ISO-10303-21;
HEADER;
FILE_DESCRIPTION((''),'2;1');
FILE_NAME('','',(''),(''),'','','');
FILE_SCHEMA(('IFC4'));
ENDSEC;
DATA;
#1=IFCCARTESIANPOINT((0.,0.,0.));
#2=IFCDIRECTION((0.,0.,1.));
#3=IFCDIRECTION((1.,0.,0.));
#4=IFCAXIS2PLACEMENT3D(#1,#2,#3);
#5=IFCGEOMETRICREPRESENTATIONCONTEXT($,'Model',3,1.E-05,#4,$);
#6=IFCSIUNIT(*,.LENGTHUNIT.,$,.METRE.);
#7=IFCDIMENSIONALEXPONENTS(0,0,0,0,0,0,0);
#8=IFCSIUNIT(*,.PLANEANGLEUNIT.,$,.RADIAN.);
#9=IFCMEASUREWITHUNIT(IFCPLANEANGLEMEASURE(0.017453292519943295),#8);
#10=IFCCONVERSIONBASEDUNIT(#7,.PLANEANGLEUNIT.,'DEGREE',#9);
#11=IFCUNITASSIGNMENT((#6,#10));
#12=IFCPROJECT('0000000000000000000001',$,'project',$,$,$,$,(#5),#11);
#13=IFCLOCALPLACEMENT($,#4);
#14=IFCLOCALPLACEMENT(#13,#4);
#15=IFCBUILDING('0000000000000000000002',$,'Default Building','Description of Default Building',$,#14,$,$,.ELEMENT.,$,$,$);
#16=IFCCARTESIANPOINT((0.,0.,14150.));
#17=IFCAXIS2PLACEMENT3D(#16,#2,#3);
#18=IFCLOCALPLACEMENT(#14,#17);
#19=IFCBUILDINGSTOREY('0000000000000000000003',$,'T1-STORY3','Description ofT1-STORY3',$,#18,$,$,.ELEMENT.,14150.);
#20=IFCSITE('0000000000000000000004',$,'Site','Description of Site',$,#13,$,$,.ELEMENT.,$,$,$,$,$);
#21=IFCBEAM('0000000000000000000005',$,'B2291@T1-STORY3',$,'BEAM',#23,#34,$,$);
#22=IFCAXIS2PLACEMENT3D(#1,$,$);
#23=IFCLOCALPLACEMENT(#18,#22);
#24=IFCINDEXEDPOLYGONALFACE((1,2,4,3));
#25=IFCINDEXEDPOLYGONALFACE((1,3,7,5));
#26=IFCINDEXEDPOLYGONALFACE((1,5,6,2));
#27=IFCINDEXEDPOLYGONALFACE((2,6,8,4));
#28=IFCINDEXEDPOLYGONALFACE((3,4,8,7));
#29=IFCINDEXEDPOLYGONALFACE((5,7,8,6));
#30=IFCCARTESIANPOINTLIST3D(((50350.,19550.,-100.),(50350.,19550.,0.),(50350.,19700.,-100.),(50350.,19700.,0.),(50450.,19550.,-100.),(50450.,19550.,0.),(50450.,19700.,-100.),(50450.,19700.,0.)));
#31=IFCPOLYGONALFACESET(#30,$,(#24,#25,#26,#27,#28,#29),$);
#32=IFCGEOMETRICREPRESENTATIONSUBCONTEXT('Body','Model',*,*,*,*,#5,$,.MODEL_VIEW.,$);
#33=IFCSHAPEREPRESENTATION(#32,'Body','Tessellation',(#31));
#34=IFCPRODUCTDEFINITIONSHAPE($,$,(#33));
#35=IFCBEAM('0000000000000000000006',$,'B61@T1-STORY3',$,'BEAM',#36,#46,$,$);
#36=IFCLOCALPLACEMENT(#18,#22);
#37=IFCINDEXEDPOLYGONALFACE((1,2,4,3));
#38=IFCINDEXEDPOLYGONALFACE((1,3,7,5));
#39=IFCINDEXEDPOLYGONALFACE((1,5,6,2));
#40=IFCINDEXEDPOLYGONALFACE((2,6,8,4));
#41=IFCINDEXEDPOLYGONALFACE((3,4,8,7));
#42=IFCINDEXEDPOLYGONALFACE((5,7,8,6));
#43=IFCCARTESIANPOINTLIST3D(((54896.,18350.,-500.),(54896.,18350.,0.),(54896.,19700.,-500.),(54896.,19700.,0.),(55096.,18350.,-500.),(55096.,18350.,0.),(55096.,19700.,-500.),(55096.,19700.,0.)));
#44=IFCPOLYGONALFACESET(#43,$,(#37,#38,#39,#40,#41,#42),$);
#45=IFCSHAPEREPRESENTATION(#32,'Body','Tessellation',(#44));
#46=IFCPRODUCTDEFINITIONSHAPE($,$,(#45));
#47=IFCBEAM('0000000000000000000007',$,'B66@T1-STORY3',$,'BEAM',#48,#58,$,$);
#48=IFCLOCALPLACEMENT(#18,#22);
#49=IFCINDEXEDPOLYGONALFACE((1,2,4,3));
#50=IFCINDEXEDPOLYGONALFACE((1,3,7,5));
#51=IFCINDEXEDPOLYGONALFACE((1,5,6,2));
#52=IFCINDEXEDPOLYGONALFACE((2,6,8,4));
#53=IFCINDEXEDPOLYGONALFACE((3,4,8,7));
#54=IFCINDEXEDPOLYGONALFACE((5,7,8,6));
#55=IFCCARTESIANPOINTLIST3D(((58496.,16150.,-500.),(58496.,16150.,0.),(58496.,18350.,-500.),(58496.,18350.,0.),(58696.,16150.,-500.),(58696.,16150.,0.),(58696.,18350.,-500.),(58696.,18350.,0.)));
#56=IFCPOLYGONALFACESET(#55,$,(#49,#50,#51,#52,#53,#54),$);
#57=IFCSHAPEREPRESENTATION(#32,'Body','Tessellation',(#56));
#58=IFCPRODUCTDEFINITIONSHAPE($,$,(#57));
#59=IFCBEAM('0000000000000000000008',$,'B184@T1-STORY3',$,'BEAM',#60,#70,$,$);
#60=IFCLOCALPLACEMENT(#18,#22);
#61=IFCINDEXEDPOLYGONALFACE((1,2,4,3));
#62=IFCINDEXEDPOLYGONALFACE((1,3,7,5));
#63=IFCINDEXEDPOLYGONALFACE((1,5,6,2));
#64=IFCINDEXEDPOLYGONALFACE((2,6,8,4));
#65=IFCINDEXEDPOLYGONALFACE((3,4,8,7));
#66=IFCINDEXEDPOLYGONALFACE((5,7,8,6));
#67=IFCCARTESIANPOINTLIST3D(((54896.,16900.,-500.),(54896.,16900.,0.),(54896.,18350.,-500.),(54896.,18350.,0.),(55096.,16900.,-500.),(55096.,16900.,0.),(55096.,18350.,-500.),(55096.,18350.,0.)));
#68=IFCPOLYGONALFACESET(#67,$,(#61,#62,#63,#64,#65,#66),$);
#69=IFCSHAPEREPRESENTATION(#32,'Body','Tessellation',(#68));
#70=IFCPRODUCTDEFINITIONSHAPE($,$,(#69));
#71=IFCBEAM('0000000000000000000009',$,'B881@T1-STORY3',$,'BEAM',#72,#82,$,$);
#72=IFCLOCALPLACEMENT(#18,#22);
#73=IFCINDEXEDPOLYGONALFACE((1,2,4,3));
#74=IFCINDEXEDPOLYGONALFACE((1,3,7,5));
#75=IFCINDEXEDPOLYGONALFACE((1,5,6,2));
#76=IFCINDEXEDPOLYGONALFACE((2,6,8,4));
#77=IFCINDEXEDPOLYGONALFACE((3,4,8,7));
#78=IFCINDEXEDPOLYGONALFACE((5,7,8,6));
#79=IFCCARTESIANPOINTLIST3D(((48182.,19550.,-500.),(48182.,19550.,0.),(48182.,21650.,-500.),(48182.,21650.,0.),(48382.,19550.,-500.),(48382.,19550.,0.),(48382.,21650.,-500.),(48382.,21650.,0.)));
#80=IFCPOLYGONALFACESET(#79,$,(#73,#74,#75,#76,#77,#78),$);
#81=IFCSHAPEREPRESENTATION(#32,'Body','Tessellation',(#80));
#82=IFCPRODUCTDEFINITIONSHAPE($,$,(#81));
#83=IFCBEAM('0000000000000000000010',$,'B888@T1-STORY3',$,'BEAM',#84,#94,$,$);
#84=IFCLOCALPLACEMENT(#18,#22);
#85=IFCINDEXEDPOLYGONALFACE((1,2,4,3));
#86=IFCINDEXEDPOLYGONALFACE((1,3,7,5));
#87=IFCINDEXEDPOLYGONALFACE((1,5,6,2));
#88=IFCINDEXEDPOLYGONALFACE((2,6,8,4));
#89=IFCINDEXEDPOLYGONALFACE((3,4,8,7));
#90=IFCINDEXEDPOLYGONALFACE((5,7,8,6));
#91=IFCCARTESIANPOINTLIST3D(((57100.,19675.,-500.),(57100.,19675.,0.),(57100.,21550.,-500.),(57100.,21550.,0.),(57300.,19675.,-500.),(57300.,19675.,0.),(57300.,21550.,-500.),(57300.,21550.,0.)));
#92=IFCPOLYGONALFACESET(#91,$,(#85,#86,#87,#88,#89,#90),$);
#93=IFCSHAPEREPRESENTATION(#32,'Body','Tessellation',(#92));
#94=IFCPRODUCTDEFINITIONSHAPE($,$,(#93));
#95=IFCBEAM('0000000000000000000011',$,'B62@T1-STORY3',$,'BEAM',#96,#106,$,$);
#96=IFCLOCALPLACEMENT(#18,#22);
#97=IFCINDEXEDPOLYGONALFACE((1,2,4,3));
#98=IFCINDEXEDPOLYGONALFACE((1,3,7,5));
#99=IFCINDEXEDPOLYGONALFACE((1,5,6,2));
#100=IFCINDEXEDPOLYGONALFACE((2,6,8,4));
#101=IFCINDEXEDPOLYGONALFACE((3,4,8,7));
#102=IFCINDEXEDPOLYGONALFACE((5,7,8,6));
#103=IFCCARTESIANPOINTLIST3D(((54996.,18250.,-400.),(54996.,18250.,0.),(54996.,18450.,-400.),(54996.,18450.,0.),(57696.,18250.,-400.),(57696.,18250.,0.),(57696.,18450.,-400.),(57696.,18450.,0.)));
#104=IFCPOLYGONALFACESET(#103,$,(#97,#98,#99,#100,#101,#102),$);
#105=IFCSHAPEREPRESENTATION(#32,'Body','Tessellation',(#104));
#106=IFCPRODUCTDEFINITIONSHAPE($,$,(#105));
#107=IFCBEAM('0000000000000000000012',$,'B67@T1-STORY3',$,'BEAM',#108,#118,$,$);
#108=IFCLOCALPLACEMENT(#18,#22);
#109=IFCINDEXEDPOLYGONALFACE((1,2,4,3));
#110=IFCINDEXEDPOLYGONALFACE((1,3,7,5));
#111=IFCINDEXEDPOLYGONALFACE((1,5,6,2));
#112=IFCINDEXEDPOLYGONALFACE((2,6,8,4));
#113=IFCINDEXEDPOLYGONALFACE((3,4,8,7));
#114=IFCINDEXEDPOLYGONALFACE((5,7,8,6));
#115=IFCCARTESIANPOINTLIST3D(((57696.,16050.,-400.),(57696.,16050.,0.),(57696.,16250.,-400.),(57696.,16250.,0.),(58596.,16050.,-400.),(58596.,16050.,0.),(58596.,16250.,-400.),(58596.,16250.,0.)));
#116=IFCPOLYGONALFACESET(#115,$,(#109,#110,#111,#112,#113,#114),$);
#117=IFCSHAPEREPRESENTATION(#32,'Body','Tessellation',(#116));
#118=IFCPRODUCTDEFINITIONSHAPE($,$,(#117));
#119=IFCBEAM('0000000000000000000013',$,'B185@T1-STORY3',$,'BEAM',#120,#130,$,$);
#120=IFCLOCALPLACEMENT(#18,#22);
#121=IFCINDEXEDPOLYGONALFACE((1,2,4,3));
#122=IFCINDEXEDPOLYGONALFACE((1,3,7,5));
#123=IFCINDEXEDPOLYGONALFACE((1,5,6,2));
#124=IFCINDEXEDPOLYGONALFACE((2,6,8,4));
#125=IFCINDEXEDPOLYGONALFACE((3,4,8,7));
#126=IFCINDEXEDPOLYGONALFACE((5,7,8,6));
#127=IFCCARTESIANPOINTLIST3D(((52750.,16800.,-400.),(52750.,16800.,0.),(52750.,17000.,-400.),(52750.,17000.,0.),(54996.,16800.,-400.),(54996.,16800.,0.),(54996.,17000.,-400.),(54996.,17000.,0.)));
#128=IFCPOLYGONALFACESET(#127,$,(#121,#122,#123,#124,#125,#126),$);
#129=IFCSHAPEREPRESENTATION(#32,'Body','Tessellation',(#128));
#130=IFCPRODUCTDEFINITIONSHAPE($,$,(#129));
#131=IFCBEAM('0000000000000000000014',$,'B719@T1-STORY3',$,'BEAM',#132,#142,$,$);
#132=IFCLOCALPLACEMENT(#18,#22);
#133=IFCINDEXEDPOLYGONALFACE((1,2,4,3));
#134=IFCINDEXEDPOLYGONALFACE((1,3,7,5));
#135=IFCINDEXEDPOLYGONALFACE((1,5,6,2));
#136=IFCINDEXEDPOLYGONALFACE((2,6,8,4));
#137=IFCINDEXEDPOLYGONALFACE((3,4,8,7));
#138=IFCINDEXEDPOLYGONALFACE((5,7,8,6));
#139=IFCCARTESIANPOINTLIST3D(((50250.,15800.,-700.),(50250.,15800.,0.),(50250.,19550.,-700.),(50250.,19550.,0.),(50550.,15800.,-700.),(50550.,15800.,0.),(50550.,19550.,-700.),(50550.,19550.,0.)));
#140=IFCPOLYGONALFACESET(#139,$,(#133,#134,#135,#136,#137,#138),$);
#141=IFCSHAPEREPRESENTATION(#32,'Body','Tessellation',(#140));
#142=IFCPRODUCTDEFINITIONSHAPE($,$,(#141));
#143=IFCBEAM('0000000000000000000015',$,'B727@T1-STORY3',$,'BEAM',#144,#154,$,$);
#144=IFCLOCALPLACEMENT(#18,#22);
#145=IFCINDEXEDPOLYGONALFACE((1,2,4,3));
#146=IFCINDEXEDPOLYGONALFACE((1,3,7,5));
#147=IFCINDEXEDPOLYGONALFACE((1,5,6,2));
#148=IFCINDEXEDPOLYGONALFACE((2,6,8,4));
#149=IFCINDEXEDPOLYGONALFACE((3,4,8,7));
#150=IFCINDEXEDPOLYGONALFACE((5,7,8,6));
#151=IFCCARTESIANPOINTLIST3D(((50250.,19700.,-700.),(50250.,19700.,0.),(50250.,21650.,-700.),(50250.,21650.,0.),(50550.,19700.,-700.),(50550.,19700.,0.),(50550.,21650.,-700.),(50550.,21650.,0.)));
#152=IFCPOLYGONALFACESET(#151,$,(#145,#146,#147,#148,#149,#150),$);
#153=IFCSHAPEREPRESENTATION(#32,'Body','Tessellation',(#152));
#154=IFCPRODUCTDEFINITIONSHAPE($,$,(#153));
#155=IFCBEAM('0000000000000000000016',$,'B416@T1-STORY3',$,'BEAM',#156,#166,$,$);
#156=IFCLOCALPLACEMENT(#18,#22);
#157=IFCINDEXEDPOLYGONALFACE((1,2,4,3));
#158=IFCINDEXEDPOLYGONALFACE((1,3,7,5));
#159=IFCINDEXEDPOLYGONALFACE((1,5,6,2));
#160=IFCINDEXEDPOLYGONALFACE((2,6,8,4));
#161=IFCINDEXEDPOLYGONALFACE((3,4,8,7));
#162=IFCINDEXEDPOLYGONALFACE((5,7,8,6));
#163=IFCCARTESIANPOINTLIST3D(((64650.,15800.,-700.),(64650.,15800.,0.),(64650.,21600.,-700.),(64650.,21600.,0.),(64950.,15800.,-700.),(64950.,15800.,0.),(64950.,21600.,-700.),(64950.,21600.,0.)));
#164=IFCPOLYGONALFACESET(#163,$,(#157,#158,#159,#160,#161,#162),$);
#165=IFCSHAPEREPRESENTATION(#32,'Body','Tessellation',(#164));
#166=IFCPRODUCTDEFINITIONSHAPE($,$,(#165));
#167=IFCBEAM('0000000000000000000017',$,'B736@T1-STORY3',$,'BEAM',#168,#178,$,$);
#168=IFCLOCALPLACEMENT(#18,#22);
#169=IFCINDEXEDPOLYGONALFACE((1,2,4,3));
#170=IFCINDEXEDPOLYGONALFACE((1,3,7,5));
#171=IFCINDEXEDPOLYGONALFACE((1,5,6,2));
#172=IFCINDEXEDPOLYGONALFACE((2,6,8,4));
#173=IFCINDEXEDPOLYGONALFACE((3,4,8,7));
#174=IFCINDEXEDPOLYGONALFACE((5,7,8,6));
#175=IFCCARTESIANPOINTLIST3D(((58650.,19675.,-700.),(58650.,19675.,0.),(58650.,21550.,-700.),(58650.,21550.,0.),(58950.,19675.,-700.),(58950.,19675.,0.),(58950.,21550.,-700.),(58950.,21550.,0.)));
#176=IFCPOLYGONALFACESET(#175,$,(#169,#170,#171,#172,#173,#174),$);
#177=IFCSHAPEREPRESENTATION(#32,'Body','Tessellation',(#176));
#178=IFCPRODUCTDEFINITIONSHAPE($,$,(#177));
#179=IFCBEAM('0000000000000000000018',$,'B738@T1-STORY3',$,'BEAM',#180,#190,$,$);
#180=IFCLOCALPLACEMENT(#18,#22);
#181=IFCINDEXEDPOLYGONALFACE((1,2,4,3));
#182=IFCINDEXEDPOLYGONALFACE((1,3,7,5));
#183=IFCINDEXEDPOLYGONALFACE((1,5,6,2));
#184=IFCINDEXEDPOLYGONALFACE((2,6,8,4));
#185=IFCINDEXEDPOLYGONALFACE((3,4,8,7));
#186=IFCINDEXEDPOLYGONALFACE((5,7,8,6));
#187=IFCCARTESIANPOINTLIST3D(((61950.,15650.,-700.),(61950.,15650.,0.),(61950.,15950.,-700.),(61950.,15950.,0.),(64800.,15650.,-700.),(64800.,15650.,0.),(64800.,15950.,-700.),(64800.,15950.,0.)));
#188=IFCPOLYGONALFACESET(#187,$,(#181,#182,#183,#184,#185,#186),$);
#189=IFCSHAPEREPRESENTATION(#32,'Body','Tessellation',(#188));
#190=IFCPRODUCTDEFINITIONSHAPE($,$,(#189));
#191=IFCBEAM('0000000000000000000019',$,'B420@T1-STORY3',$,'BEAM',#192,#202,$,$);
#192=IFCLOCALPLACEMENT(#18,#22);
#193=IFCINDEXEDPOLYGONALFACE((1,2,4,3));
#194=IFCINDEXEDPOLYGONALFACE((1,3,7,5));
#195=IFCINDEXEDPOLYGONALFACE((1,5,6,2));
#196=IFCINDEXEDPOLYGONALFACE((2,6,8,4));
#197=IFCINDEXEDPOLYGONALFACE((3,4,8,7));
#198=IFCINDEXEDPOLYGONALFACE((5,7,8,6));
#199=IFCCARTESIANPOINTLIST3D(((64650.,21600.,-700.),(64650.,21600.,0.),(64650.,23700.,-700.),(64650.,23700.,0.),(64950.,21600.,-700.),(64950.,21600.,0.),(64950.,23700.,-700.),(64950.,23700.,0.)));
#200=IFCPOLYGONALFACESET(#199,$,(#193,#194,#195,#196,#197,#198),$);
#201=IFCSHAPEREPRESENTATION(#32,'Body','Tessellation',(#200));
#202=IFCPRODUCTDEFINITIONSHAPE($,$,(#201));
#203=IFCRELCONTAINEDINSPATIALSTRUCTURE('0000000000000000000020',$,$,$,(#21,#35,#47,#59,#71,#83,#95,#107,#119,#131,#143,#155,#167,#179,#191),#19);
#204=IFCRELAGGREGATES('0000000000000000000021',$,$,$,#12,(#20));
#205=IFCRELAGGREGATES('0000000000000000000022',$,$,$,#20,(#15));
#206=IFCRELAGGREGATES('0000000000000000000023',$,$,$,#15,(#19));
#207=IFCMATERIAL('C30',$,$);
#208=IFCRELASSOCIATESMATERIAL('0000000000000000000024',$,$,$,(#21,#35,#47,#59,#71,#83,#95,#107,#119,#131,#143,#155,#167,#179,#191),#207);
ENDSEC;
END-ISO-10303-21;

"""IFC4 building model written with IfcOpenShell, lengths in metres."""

from ifc_helpers import new_model, entity, si_unit, converted_unit, frame, origin_with_axes, place, context, subcontext, project, spatial, rectangle, extrude, material, element, save


model = new_model("IFC4")

# Units and contexts
model_context = context("Model", 3, precision=1e-05, world=origin_with_axes())
body_context = subcontext(model_context, "Body", "Model", "MODEL_VIEW")
ifc_project = project(units=[si_unit("LENGTHUNIT", "METRE"), converted_unit("PLANEANGLEUNIT", "DEGREE", entity("IfcPlaneAngleMeasure", 0.017453292519943295), si_unit("PLANEANGLEUNIT", "RADIAN"), dimensions=[0, 0, 0, 0, 0, 0, 0])], contexts=[model_context])

# Site, building, storey
site_placement = place(None, origin_with_axes())
site = spatial("IfcSite", under=ifc_project, at=site_placement, Name="Site", Description="Description of Site", CompositionType="ELEMENT")
building_placement = place(site_placement, origin_with_axes())
building = spatial("IfcBuilding", under=site, at=building_placement, Name="Default Building", Description="Description of Default Building", CompositionType="ELEMENT")
storey_placement = place(building_placement, frame((0.0, 0.0, 14150.0), z_axis=(0.0, 0.0, 1.0), x_axis=(1.0, 0.0, 0.0)))
storey = spatial("IfcBuildingStorey", under=building, at=storey_placement, Name="T1-STORY3", Description="Description ofT1-STORY3", CompositionType="ELEMENT", Elevation=14150.0)

# Beams
ifc_material_1 = material(Name="C30")
beam_1_placement = place(storey_placement, frame((50400.0, 19550.0, -50.0), z_axis=(0.0, 1.0, 0.0), x_axis=(-1.0, 0.0, 0.0)))
element("IfcBeam", 1, at=beam_1_placement, inside=storey, material=ifc_material_1, Name="B2291@T1-STORY3", ObjectType="BEAM", context=body_context, shape_type="SweptSolid", body=[
    extrude(rectangle(XDim=100.0, YDim=100.0), origin_with_axes(), (0.0, 0.0, 1.0), 150.0),
])
beam_2_placement = place(storey_placement, frame((54996.0, 18350.0, -250.0), z_axis=(0.0, 1.0, 0.0), x_axis=(-1.0, 0.0, 0.0)))
element("IfcBeam", 2, at=beam_2_placement, inside=storey, material=ifc_material_1, Name="B61@T1-STORY3", ObjectType="BEAM", context=body_context, shape_type="SweptSolid", body=[
    extrude(rectangle(XDim=200.0, YDim=500.0), origin_with_axes(), (0.0, 0.0, 1.0), 1350.0),
])
beam_3_placement = place(storey_placement, frame((58596.0, 16150.0, -250.0), z_axis=(0.0, 1.0, 0.0), x_axis=(-1.0, 0.0, 0.0)))
element("IfcBeam", 3, at=beam_3_placement, inside=storey, material=ifc_material_1, Name="B66@T1-STORY3", ObjectType="BEAM", context=body_context, shape_type="SweptSolid", body=[
    extrude(rectangle(XDim=200.0, YDim=500.0), origin_with_axes(), (0.0, 0.0, 1.0), 2200.0),
])
beam_4_placement = place(storey_placement, frame((54996.0, 16900.0, -250.0), z_axis=(0.0, 1.0, 0.0), x_axis=(-1.0, 0.0, 0.0)))
element("IfcBeam", 4, at=beam_4_placement, inside=storey, material=ifc_material_1, Name="B184@T1-STORY3", ObjectType="BEAM", context=body_context, shape_type="SweptSolid", body=[
    extrude(rectangle(XDim=200.0, YDim=500.0), origin_with_axes(), (0.0, 0.0, 1.0), 1450.0),
])
beam_5_placement = place(storey_placement, frame((48282.0, 19550.0, -250.0), z_axis=(0.0, 1.0, 0.0), x_axis=(-1.0, 0.0, 0.0)))
element("IfcBeam", 5, at=beam_5_placement, inside=storey, material=ifc_material_1, Name="B881@T1-STORY3", ObjectType="BEAM", context=body_context, shape_type="SweptSolid", body=[
    extrude(rectangle(XDim=200.0, YDim=500.0), origin_with_axes(), (0.0, 0.0, 1.0), 2100.0),
])
beam_6_placement = place(storey_placement, frame((57200.0, 19675.0, -250.0), z_axis=(0.0, 1.0, 0.0), x_axis=(-1.0, 0.0, 0.0)))
element("IfcBeam", 6, at=beam_6_placement, inside=storey, material=ifc_material_1, Name="B888@T1-STORY3", ObjectType="BEAM", context=body_context, shape_type="SweptSolid", body=[
    extrude(rectangle(XDim=200.0, YDim=500.0), origin_with_axes(), (0.0, 0.0, 1.0), 1875.0),
])
beam_7_placement = place(storey_placement, frame((54996.0, 18350.0, -200.0), z_axis=(1.0, 0.0, 0.0), x_axis=(0.0, 1.0, 0.0)))
element("IfcBeam", 7, at=beam_7_placement, inside=storey, material=ifc_material_1, Name="B62@T1-STORY3", ObjectType="BEAM", context=body_context, shape_type="SweptSolid", body=[
    extrude(rectangle(XDim=200.0, YDim=400.0), origin_with_axes(), (0.0, 0.0, 1.0), 2700.0),
])
beam_8_placement = place(storey_placement, frame((57696.0, 16150.0, -200.0), z_axis=(1.0, 0.0, 0.0), x_axis=(0.0, 1.0, 0.0)))
element("IfcBeam", 8, at=beam_8_placement, inside=storey, material=ifc_material_1, Name="B67@T1-STORY3", ObjectType="BEAM", context=body_context, shape_type="SweptSolid", body=[
    extrude(rectangle(XDim=200.0, YDim=400.0), origin_with_axes(), (0.0, 0.0, 1.0), 900.0),
])
beam_9_placement = place(storey_placement, frame((52750.0, 16900.0, -200.0), z_axis=(1.0, 0.0, 0.0), x_axis=(0.0, 1.0, 0.0)))
element("IfcBeam", 9, at=beam_9_placement, inside=storey, material=ifc_material_1, Name="B185@T1-STORY3", ObjectType="BEAM", context=body_context, shape_type="SweptSolid", body=[
    extrude(rectangle(XDim=200.0, YDim=400.0), origin_with_axes(), (0.0, 0.0, 1.0), 2246.0),
])
beam_10_placement = place(storey_placement, frame((50400.0, 15800.0, -350.0), z_axis=(0.0, 1.0, 0.0), x_axis=(-1.0, 0.0, 0.0)))
element("IfcBeam", 10, at=beam_10_placement, inside=storey, material=ifc_material_1, Name="B719@T1-STORY3", ObjectType="BEAM", context=body_context, shape_type="SweptSolid", body=[
    extrude(rectangle(XDim=300.0, YDim=700.0), origin_with_axes(), (0.0, 0.0, 1.0), 3750.0),
])
beam_11_placement = place(storey_placement, frame((50400.0, 19700.0, -350.0), z_axis=(0.0, 1.0, 0.0), x_axis=(-1.0, 0.0, 0.0)))
element("IfcBeam", 11, at=beam_11_placement, inside=storey, material=ifc_material_1, Name="B727@T1-STORY3", ObjectType="BEAM", context=body_context, shape_type="SweptSolid", body=[
    extrude(rectangle(XDim=300.0, YDim=700.0), origin_with_axes(), (0.0, 0.0, 1.0), 1950.0),
])
beam_12_placement = place(storey_placement, frame((64800.0, 15800.0, -350.0), z_axis=(0.0, 1.0, 0.0), x_axis=(-1.0, 0.0, 0.0)))
element("IfcBeam", 12, at=beam_12_placement, inside=storey, material=ifc_material_1, Name="B416@T1-STORY3", ObjectType="BEAM", context=body_context, shape_type="SweptSolid", body=[
    extrude(rectangle(XDim=300.0, YDim=700.0), origin_with_axes(), (0.0, 0.0, 1.0), 5800.0),
])
beam_13_placement = place(storey_placement, frame((58800.0, 19675.0, -350.0), z_axis=(0.0, 1.0, 0.0), x_axis=(-1.0, 0.0, 0.0)))
element("IfcBeam", 13, at=beam_13_placement, inside=storey, material=ifc_material_1, Name="B736@T1-STORY3", ObjectType="BEAM", context=body_context, shape_type="SweptSolid", body=[
    extrude(rectangle(XDim=300.0, YDim=700.0), origin_with_axes(), (0.0, 0.0, 1.0), 1875.0),
])
beam_14_placement = place(storey_placement, frame((61950.0, 15800.0, -350.0), z_axis=(1.0, 0.0, 0.0), x_axis=(0.0, 1.0, 0.0)))
element("IfcBeam", 14, at=beam_14_placement, inside=storey, material=ifc_material_1, Name="B738@T1-STORY3", ObjectType="BEAM", context=body_context, shape_type="SweptSolid", body=[
    extrude(rectangle(XDim=300.0, YDim=700.0), origin_with_axes(), (0.0, 0.0, 1.0), 2850.0),
])
beam_15_placement = place(storey_placement, frame((64800.0, 21600.0, -350.0), z_axis=(0.0, 1.0, 0.0), x_axis=(-1.0, 0.0, 0.0)))
element("IfcBeam", 15, at=beam_15_placement, inside=storey, material=ifc_material_1, Name="B420@T1-STORY3", ObjectType="BEAM", context=body_context, shape_type="SweptSolid", body=[
    extrude(rectangle(XDim=300.0, YDim=700.0), origin_with_axes(), (0.0, 0.0, 1.0), 2100.0),
])

save(model, "model.ifc")
